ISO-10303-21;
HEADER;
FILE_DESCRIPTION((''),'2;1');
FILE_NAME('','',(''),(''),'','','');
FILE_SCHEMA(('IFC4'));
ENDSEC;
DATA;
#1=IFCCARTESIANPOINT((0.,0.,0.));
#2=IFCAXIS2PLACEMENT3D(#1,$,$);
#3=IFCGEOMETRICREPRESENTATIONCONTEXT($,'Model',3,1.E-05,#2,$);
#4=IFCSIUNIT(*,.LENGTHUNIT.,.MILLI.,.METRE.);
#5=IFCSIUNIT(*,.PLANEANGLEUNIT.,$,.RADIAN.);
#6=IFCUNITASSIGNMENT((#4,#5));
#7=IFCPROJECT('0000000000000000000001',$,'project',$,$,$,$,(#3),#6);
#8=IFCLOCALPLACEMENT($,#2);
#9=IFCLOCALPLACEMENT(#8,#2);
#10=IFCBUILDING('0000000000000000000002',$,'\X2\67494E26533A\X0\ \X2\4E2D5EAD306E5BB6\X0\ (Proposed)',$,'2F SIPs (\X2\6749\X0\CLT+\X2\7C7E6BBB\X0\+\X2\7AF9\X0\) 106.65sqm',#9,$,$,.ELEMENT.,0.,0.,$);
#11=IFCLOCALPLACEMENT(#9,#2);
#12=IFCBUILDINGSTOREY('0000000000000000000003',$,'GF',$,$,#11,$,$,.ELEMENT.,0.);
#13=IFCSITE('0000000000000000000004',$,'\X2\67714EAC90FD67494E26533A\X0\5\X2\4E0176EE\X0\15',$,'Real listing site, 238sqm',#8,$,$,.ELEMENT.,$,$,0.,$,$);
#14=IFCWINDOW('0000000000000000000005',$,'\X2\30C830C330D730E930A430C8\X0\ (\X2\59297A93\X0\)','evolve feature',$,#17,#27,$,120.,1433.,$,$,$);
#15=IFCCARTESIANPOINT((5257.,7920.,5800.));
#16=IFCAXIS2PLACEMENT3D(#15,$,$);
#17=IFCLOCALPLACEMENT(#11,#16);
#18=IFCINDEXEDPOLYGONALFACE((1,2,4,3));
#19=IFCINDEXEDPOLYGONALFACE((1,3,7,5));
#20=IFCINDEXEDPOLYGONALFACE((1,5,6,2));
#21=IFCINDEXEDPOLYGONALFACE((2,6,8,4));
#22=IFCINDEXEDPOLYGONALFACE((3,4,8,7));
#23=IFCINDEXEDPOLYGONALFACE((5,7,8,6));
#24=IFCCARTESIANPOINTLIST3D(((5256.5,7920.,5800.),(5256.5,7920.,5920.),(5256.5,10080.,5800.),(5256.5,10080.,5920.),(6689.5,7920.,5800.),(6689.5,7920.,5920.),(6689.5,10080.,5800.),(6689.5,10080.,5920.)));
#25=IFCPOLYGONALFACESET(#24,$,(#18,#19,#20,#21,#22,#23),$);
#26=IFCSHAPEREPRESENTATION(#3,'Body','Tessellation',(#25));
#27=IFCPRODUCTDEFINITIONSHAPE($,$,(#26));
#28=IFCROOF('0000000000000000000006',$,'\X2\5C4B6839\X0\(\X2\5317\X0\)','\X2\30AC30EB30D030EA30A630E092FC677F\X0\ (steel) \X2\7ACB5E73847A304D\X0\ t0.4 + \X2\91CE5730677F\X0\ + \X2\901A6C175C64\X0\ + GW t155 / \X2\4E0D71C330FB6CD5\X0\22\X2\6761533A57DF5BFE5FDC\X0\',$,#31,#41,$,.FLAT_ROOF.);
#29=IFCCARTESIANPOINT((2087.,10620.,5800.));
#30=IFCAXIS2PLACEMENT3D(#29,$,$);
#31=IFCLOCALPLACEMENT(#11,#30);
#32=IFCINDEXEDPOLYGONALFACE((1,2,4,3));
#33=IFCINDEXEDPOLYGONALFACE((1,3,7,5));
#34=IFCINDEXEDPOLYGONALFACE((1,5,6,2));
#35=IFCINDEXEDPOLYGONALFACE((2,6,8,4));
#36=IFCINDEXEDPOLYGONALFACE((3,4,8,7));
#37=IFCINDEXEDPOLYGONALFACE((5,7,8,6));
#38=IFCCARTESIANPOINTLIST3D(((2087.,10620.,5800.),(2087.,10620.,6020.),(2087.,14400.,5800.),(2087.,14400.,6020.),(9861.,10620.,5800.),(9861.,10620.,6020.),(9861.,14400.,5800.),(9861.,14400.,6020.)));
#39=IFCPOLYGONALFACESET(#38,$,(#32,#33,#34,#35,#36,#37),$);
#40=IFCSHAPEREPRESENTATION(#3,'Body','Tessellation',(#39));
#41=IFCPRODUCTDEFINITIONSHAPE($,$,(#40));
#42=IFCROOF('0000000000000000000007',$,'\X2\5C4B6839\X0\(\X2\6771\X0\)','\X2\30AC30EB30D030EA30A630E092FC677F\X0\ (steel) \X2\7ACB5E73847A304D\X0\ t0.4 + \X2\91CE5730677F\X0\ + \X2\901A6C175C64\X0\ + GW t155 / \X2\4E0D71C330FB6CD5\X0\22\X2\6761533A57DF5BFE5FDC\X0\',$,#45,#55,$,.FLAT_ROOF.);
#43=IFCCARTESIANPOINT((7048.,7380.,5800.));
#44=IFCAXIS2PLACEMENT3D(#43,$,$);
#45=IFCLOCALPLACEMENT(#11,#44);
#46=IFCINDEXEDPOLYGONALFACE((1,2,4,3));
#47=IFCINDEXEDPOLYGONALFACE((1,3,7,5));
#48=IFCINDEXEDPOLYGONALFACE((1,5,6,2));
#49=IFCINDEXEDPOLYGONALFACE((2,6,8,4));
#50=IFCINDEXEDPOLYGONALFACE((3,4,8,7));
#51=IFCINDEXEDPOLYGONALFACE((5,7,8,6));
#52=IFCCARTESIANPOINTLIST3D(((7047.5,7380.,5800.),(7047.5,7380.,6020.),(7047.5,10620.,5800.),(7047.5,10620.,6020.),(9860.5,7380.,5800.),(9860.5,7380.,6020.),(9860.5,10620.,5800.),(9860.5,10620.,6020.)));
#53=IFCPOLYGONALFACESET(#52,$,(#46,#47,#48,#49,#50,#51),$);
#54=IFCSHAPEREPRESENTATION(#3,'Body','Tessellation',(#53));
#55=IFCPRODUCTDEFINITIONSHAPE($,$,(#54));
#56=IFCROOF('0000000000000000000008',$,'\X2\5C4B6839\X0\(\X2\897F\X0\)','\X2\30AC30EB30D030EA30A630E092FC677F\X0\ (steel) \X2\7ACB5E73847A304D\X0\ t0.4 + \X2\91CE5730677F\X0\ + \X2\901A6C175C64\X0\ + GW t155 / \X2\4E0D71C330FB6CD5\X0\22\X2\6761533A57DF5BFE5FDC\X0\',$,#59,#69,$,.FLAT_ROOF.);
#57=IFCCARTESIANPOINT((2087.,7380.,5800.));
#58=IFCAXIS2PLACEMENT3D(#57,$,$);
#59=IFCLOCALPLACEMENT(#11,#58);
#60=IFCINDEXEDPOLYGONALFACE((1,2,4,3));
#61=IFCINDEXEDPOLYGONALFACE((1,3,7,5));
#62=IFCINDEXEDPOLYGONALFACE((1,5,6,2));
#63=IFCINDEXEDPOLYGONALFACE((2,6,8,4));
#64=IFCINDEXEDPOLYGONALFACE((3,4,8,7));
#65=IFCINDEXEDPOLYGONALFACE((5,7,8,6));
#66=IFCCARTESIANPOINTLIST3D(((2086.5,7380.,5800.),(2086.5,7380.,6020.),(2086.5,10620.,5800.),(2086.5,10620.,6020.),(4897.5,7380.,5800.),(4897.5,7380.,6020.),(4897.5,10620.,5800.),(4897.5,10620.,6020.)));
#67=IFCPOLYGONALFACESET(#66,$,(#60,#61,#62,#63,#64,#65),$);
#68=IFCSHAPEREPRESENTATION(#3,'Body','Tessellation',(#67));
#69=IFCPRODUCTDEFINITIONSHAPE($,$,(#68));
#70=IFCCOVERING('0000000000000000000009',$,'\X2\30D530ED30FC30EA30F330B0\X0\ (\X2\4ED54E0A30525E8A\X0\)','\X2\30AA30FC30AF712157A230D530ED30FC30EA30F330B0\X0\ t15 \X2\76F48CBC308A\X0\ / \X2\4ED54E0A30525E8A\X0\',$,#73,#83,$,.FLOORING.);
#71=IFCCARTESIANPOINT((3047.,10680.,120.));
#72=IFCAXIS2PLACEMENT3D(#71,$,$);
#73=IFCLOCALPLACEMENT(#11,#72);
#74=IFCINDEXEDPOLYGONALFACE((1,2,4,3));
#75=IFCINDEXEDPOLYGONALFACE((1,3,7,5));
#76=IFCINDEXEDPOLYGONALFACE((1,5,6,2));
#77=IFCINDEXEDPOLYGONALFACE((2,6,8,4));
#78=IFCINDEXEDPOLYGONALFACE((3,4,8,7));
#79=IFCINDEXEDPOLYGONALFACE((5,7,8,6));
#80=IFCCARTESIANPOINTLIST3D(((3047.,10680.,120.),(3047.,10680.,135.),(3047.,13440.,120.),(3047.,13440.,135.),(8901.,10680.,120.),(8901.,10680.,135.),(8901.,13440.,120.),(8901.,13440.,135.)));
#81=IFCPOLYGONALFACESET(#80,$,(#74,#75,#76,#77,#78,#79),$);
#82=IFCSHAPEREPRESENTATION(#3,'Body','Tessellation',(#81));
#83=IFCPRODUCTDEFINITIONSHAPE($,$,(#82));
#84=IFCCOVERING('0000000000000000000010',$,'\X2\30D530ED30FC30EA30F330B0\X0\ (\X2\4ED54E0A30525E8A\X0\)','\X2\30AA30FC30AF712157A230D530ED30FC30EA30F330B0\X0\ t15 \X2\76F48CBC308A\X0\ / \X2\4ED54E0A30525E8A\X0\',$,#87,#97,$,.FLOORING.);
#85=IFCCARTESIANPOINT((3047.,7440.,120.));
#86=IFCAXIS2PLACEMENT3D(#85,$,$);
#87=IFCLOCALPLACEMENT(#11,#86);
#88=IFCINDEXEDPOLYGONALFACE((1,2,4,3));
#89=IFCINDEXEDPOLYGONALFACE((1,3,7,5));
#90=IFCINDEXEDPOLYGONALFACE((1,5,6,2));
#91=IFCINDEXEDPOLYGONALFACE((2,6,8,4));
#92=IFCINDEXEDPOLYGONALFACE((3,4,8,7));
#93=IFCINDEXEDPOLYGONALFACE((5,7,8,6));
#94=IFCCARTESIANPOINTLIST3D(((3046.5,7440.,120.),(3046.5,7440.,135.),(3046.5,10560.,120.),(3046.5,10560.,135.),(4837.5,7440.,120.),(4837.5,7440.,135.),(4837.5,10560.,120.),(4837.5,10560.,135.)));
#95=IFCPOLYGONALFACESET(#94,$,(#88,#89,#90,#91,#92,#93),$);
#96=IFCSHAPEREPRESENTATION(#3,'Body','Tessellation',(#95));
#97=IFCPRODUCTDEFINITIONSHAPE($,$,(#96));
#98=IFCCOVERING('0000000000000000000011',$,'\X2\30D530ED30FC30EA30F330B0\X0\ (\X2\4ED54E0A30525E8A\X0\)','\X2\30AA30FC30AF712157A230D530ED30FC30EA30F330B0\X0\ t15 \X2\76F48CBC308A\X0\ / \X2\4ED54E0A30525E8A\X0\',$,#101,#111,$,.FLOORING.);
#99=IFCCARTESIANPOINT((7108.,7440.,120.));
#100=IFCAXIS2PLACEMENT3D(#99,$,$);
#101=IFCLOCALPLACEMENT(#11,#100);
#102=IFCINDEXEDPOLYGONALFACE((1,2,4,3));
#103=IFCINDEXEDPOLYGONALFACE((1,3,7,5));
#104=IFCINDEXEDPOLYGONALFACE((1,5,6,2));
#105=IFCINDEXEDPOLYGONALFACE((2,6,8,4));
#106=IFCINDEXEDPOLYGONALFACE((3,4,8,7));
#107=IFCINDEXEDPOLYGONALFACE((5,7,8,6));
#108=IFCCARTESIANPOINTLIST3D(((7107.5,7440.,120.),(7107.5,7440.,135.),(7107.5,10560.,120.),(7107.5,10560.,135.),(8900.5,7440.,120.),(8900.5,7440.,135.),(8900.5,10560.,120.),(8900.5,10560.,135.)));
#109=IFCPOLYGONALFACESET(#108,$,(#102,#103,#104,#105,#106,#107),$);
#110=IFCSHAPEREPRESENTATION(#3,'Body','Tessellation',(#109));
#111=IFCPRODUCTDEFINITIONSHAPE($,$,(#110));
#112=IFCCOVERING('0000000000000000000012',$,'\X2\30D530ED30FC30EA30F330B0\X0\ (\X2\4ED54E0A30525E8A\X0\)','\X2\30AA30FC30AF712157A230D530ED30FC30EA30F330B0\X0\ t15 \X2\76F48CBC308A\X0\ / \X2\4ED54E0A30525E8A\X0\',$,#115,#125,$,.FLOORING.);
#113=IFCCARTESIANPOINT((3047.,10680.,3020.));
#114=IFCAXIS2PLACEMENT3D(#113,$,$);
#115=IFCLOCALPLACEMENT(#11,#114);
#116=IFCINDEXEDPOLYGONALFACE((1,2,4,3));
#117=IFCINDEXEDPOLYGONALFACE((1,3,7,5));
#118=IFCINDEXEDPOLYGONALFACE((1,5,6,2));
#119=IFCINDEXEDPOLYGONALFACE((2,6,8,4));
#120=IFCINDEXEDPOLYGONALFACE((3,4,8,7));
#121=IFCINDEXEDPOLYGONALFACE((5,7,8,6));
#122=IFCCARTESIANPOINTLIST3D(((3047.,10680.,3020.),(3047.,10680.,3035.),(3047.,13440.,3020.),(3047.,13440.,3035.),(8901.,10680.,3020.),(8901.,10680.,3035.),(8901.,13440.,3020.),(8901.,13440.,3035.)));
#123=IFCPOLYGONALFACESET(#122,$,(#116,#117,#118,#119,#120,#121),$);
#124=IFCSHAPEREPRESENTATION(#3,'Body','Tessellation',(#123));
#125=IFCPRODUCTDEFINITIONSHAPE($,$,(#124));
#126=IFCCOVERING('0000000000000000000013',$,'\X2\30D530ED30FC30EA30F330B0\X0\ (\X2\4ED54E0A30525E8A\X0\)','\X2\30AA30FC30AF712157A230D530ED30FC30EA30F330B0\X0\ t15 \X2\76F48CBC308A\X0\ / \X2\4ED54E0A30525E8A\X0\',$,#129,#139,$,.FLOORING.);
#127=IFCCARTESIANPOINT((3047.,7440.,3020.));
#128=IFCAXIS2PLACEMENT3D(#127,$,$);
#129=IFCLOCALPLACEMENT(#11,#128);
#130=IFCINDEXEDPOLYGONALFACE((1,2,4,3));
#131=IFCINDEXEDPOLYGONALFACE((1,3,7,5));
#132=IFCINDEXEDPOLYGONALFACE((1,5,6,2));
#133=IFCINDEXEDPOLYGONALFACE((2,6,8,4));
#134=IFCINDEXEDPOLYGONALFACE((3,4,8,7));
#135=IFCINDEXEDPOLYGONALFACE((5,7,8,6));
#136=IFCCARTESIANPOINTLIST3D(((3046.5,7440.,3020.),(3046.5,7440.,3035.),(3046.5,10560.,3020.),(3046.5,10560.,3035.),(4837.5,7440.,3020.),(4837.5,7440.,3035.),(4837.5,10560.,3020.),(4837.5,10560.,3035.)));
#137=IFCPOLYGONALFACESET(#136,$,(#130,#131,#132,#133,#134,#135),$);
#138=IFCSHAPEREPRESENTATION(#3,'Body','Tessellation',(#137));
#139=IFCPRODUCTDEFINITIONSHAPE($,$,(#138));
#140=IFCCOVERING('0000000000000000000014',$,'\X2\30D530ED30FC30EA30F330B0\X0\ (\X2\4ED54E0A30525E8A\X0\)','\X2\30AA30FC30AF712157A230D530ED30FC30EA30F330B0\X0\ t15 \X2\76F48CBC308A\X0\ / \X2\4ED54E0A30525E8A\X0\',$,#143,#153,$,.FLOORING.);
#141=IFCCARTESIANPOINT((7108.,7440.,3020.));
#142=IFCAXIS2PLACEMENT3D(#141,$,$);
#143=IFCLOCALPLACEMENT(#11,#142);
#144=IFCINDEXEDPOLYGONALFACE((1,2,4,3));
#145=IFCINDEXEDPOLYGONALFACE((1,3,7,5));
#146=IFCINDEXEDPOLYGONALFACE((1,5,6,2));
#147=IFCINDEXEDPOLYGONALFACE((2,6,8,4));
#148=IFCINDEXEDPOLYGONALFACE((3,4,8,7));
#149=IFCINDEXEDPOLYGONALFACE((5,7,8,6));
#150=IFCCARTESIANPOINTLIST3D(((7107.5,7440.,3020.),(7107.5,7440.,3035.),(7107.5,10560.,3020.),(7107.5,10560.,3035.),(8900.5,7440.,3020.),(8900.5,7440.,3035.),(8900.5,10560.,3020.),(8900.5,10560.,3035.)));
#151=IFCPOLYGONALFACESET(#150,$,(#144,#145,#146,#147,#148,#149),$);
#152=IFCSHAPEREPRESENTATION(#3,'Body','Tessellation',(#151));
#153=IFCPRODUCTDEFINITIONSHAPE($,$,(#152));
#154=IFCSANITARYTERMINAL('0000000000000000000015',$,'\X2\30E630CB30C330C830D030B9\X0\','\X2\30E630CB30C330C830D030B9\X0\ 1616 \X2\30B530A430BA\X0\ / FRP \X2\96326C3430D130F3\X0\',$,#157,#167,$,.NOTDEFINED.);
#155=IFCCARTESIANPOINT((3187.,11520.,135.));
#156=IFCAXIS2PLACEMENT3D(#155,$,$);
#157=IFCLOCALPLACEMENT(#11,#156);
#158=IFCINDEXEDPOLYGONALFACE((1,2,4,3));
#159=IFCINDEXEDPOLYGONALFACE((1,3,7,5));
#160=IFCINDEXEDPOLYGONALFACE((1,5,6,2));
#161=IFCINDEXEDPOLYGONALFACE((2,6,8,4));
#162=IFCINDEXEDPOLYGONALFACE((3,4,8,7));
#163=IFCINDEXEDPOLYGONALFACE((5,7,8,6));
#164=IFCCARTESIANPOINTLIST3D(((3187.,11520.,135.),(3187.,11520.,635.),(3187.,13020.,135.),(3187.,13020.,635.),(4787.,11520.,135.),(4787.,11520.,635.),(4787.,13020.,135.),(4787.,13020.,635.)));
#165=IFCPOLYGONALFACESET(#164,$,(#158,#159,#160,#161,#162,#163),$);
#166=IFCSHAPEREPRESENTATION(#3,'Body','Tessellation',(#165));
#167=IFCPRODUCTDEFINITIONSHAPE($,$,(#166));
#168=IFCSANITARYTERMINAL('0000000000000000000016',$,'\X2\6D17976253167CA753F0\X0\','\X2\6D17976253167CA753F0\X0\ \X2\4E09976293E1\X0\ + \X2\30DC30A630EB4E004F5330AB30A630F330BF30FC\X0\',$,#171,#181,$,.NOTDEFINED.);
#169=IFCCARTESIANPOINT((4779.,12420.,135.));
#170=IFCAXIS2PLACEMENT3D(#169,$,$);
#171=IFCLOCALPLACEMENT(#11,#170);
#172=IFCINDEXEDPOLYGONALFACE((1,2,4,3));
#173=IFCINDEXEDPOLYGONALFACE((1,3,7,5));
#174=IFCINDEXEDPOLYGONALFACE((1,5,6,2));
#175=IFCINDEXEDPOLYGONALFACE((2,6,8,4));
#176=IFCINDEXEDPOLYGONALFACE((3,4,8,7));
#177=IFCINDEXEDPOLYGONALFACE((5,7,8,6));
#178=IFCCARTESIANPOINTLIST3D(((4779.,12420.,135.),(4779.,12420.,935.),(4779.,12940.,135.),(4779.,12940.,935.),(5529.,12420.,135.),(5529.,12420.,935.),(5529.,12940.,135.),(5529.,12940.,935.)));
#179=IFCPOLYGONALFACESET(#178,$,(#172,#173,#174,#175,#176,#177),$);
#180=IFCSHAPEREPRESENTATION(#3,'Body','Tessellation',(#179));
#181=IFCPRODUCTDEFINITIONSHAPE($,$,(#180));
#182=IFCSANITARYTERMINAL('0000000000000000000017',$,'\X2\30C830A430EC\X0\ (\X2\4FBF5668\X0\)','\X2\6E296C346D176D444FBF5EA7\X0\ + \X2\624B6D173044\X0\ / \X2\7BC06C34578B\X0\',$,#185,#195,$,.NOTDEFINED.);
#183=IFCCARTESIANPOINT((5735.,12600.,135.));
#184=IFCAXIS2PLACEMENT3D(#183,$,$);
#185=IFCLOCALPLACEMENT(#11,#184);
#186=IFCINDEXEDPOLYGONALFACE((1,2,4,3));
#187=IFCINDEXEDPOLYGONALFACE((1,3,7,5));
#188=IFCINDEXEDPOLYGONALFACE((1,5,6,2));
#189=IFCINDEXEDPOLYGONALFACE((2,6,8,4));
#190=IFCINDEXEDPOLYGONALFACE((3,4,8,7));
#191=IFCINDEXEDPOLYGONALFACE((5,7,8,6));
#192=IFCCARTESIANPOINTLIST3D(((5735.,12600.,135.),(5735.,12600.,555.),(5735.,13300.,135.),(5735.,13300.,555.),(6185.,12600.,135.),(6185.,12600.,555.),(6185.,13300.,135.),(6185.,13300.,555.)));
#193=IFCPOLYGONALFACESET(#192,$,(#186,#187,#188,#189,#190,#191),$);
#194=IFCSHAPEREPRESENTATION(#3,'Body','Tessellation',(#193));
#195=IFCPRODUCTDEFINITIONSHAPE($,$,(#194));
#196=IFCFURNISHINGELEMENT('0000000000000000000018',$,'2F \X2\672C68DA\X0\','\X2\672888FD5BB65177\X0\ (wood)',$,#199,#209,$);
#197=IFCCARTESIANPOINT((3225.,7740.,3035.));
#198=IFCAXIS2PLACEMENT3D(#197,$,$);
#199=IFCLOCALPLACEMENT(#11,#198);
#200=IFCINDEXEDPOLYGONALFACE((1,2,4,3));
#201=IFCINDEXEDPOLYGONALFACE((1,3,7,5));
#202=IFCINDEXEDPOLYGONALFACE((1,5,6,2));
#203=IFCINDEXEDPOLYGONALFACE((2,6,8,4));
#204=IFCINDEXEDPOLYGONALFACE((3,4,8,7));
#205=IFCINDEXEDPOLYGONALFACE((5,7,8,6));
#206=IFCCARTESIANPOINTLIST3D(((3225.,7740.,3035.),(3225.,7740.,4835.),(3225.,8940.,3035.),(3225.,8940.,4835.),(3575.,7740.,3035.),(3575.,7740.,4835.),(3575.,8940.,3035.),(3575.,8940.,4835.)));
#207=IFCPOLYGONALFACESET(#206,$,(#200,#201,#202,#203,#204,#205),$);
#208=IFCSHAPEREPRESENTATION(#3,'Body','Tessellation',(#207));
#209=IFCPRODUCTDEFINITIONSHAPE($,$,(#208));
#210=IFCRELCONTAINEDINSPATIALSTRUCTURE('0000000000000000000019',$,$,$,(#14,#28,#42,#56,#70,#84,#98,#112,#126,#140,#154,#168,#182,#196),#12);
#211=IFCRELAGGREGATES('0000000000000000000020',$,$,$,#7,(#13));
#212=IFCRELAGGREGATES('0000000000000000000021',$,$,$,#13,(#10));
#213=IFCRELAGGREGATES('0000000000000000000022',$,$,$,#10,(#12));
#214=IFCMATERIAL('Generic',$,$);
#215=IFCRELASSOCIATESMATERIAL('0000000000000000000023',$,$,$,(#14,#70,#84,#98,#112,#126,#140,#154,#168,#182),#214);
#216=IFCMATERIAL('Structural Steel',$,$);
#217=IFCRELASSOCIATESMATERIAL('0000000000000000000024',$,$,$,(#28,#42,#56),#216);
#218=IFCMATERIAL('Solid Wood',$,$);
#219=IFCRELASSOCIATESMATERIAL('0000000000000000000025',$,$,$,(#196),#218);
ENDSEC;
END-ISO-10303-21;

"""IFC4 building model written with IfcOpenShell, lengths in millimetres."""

from ifc_helpers import new_model, si_unit, frame, frame_2d, origin, place, context, project, spatial, rectangle, extrude, material, element, save


model = new_model("IFC4")

# Units and contexts
model_context = context("Model", 3, precision=1e-05, world=origin())
ifc_project = project(units=[si_unit("LENGTHUNIT", "METRE", prefix="MILLI"), si_unit("PLANEANGLEUNIT", "RADIAN")], contexts=[model_context])

# Site, building, storey
site_placement = place(None, origin())
site = spatial("IfcSite", under=ifc_project, at=site_placement, Name="東京都杉並区5丁目15", ObjectType="Real listing site, 238sqm", CompositionType="ELEMENT", RefElevation=0.0)
building_placement = place(site_placement, origin())
building = spatial("IfcBuilding", under=site, at=building_placement, Name="杉並区 中庭の家 (Proposed)", ObjectType="2F SIPs (杉CLT+籾殻+竹) 106.65sqm", CompositionType="ELEMENT", ElevationOfRefHeight=0.0, ElevationOfTerrain=0.0)
storey_placement = place(building_placement, origin())
storey = spatial("IfcBuildingStorey", under=building, at=storey_placement, Name="GF", CompositionType="ELEMENT", Elevation=0.0)

# Shared definitions
ifc_material_1 = material(Name="Solid Wood")

# Window
ifc_material_2 = material(Name="Generic")
window_1_placement = place(storey_placement, frame((5257.0, 7920.0, 5800.0)))
element("IfcWindow", 1, at=window_1_placement, inside=storey, material=ifc_material_2, Name="トップライト (天窓)", Description="evolve feature", OverallHeight=120.0, OverallWidth=1433.0, context=model_context, shape_type="SweptSolid", body=[
    extrude(rectangle(XDim=1433.0, YDim=2160.0, at=frame_2d((716.0, 1080.0))), frame((5257.0, 7920.0, 5800.0)), (0.0, 0.0, 1.0), 120.0),
])

# Roofs
ifc_material_3 = material(Name="Structural Steel")
roof_1_placement = place(storey_placement, frame((2087.0, 10620.0, 5800.0)))
element("IfcRoof", 2, at=roof_1_placement, inside=storey, material=ifc_material_3, Name="屋根(北)", Description="ガルバリウム鋼板 (steel) 立平葺き t0.4 + 野地板 + 通気層 + GW t155 / 不燃・法22条区域対応", PredefinedType="FLAT_ROOF", context=model_context, shape_type="SweptSolid", body=[
    extrude(rectangle(XDim=7774.0, YDim=3780.0, at=frame_2d((3887.0, 1890.0))), frame((2087.0, 10620.0, 5800.0)), (0.0, 0.0, 1.0), 220.0),
])
roof_2_placement = place(storey_placement, frame((7048.0, 7380.0, 5800.0)))
element("IfcRoof", 3, at=roof_2_placement, inside=storey, material=ifc_material_3, Name="屋根(東)", Description="ガルバリウム鋼板 (steel) 立平葺き t0.4 + 野地板 + 通気層 + GW t155 / 不燃・法22条区域対応", PredefinedType="FLAT_ROOF", context=model_context, shape_type="SweptSolid", body=[
    extrude(rectangle(XDim=2813.0, YDim=3240.0, at=frame_2d((1406.0, 1620.0))), frame((7048.0, 7380.0, 5800.0)), (0.0, 0.0, 1.0), 220.0),
])
roof_3_placement = place(storey_placement, frame((2087.0, 7380.0, 5800.0)))
element("IfcRoof", 4, at=roof_3_placement, inside=storey, material=ifc_material_3, Name="屋根(西)", Description="ガルバリウム鋼板 (steel) 立平葺き t0.4 + 野地板 + 通気層 + GW t155 / 不燃・法22条区域対応", PredefinedType="FLAT_ROOF", context=model_context, shape_type="SweptSolid", body=[
    extrude(rectangle(XDim=2811.0, YDim=3240.0, at=frame_2d((1405.0, 1620.0))), frame((2087.0, 7380.0, 5800.0)), (0.0, 0.0, 1.0), 220.0),
])

# Coverings
covering_1_placement = place(storey_placement, frame((3047.0, 10680.0, 120.0)))
element("IfcCovering", 5, at=covering_1_placement, inside=storey, material=ifc_material_2, Name="フローリング (仕上げ床)", Description="オーク無垢フローリング t15 直貼り / 仕上げ床", PredefinedType="FLOORING", context=model_context, shape_type="SweptSolid", body=[
    extrude(rectangle(XDim=5854.0, YDim=2760.0, at=frame_2d((2927.0, 1380.0))), frame((3047.0, 10680.0, 120.0)), (0.0, 0.0, 1.0), 15.0),
])
covering_2_placement = place(storey_placement, frame((3047.0, 7440.0, 120.0)))
element("IfcCovering", 6, at=covering_2_placement, inside=storey, material=ifc_material_2, Name="フローリング (仕上げ床)", Description="オーク無垢フローリング t15 直貼り / 仕上げ床", PredefinedType="FLOORING", context=model_context, shape_type="SweptSolid", body=[
    extrude(rectangle(XDim=1791.0, YDim=3120.0, at=frame_2d((895.0, 1560.0))), frame((3047.0, 7440.0, 120.0)), (0.0, 0.0, 1.0), 15.0),
])
covering_3_placement = place(storey_placement, frame((7108.0, 7440.0, 120.0)))
element("IfcCovering", 7, at=covering_3_placement, inside=storey, material=ifc_material_2, Name="フローリング (仕上げ床)", Description="オーク無垢フローリング t15 直貼り / 仕上げ床", PredefinedType="FLOORING", context=model_context, shape_type="SweptSolid", body=[
    extrude(rectangle(XDim=1793.0, YDim=3120.0, at=frame_2d((896.0, 1560.0))), frame((7108.0, 7440.0, 120.0)), (0.0, 0.0, 1.0), 15.0),
])
covering_4_placement = place(storey_placement, frame((3047.0, 10680.0, 3020.0)))
element("IfcCovering", 8, at=covering_4_placement, inside=storey, material=ifc_material_2, Name="フローリング (仕上げ床)", Description="オーク無垢フローリング t15 直貼り / 仕上げ床", PredefinedType="FLOORING", context=model_context, shape_type="SweptSolid", body=[
    extrude(rectangle(XDim=5854.0, YDim=2760.0, at=frame_2d((2927.0, 1380.0))), frame((3047.0, 10680.0, 3020.0)), (0.0, 0.0, 1.0), 15.0),
])
covering_5_placement = place(storey_placement, frame((3047.0, 7440.0, 3020.0)))
element("IfcCovering", 9, at=covering_5_placement, inside=storey, material=ifc_material_2, Name="フローリング (仕上げ床)", Description="オーク無垢フローリング t15 直貼り / 仕上げ床", PredefinedType="FLOORING", context=model_context, shape_type="SweptSolid", body=[
    extrude(rectangle(XDim=1791.0, YDim=3120.0, at=frame_2d((895.0, 1560.0))), frame((3047.0, 7440.0, 3020.0)), (0.0, 0.0, 1.0), 15.0),
])
covering_6_placement = place(storey_placement, frame((7108.0, 7440.0, 3020.0)))
element("IfcCovering", 10, at=covering_6_placement, inside=storey, material=ifc_material_2, Name="フローリング (仕上げ床)", Description="オーク無垢フローリング t15 直貼り / 仕上げ床", PredefinedType="FLOORING", context=model_context, shape_type="SweptSolid", body=[
    extrude(rectangle(XDim=1793.0, YDim=3120.0, at=frame_2d((896.0, 1560.0))), frame((7108.0, 7440.0, 3020.0)), (0.0, 0.0, 1.0), 15.0),
])

# Sanitary terminals
sanitary_terminal_1_placement = place(storey_placement, frame((3187.0, 11520.0, 135.0)))
element("IfcSanitaryTerminal", 11, at=sanitary_terminal_1_placement, inside=storey, material=ifc_material_2, Name="ユニットバス", Description="ユニットバス 1616 サイズ / FRP 防水パン", PredefinedType="NOTDEFINED", context=model_context, shape_type="SweptSolid", body=[
    extrude(rectangle(XDim=1600.0, YDim=1500.0, at=frame_2d((800.0, 750.0))), frame((3187.0, 11520.0, 135.0)), (0.0, 0.0, 1.0), 500.0),
])
sanitary_terminal_2_placement = place(storey_placement, frame((4779.0, 12420.0, 135.0)))
element("IfcSanitaryTerminal", 12, at=sanitary_terminal_2_placement, inside=storey, material=ifc_material_2, Name="洗面化粧台", Description="洗面化粧台 三面鏡 + ボウル一体カウンター", PredefinedType="NOTDEFINED", context=model_context, shape_type="SweptSolid", body=[
    extrude(rectangle(XDim=750.0, YDim=520.0, at=frame_2d((375.0, 260.0))), frame((4779.0, 12420.0, 135.0)), (0.0, 0.0, 1.0), 800.0),
])
sanitary_terminal_3_placement = place(storey_placement, frame((5735.0, 12600.0, 135.0)))
element("IfcSanitaryTerminal", 13, at=sanitary_terminal_3_placement, inside=storey, material=ifc_material_2, Name="トイレ (便器)", Description="温水洗浄便座 + 手洗い / 節水型", PredefinedType="NOTDEFINED", context=model_context, shape_type="SweptSolid", body=[
    extrude(rectangle(XDim=450.0, YDim=700.0, at=frame_2d((225.0, 350.0))), frame((5735.0, 12600.0, 135.0)), (0.0, 0.0, 1.0), 420.0),
])

# Furnishing element
furnishing_placement = place(storey_placement, frame((3225.0, 7740.0, 3035.0)))
element("IfcFurnishingElement", 14, at=furnishing_placement, inside=storey, material=ifc_material_1, Name="2F 本棚", Description="木製家具 (wood)", context=model_context, shape_type="SweptSolid", body=[
    extrude(rectangle(XDim=350.0, YDim=1200.0, at=frame_2d((175.0, 600.0))), frame((3225.0, 7740.0, 3035.0)), (0.0, 0.0, 1.0), 1800.0),
])

save(model, "model.ifc")
